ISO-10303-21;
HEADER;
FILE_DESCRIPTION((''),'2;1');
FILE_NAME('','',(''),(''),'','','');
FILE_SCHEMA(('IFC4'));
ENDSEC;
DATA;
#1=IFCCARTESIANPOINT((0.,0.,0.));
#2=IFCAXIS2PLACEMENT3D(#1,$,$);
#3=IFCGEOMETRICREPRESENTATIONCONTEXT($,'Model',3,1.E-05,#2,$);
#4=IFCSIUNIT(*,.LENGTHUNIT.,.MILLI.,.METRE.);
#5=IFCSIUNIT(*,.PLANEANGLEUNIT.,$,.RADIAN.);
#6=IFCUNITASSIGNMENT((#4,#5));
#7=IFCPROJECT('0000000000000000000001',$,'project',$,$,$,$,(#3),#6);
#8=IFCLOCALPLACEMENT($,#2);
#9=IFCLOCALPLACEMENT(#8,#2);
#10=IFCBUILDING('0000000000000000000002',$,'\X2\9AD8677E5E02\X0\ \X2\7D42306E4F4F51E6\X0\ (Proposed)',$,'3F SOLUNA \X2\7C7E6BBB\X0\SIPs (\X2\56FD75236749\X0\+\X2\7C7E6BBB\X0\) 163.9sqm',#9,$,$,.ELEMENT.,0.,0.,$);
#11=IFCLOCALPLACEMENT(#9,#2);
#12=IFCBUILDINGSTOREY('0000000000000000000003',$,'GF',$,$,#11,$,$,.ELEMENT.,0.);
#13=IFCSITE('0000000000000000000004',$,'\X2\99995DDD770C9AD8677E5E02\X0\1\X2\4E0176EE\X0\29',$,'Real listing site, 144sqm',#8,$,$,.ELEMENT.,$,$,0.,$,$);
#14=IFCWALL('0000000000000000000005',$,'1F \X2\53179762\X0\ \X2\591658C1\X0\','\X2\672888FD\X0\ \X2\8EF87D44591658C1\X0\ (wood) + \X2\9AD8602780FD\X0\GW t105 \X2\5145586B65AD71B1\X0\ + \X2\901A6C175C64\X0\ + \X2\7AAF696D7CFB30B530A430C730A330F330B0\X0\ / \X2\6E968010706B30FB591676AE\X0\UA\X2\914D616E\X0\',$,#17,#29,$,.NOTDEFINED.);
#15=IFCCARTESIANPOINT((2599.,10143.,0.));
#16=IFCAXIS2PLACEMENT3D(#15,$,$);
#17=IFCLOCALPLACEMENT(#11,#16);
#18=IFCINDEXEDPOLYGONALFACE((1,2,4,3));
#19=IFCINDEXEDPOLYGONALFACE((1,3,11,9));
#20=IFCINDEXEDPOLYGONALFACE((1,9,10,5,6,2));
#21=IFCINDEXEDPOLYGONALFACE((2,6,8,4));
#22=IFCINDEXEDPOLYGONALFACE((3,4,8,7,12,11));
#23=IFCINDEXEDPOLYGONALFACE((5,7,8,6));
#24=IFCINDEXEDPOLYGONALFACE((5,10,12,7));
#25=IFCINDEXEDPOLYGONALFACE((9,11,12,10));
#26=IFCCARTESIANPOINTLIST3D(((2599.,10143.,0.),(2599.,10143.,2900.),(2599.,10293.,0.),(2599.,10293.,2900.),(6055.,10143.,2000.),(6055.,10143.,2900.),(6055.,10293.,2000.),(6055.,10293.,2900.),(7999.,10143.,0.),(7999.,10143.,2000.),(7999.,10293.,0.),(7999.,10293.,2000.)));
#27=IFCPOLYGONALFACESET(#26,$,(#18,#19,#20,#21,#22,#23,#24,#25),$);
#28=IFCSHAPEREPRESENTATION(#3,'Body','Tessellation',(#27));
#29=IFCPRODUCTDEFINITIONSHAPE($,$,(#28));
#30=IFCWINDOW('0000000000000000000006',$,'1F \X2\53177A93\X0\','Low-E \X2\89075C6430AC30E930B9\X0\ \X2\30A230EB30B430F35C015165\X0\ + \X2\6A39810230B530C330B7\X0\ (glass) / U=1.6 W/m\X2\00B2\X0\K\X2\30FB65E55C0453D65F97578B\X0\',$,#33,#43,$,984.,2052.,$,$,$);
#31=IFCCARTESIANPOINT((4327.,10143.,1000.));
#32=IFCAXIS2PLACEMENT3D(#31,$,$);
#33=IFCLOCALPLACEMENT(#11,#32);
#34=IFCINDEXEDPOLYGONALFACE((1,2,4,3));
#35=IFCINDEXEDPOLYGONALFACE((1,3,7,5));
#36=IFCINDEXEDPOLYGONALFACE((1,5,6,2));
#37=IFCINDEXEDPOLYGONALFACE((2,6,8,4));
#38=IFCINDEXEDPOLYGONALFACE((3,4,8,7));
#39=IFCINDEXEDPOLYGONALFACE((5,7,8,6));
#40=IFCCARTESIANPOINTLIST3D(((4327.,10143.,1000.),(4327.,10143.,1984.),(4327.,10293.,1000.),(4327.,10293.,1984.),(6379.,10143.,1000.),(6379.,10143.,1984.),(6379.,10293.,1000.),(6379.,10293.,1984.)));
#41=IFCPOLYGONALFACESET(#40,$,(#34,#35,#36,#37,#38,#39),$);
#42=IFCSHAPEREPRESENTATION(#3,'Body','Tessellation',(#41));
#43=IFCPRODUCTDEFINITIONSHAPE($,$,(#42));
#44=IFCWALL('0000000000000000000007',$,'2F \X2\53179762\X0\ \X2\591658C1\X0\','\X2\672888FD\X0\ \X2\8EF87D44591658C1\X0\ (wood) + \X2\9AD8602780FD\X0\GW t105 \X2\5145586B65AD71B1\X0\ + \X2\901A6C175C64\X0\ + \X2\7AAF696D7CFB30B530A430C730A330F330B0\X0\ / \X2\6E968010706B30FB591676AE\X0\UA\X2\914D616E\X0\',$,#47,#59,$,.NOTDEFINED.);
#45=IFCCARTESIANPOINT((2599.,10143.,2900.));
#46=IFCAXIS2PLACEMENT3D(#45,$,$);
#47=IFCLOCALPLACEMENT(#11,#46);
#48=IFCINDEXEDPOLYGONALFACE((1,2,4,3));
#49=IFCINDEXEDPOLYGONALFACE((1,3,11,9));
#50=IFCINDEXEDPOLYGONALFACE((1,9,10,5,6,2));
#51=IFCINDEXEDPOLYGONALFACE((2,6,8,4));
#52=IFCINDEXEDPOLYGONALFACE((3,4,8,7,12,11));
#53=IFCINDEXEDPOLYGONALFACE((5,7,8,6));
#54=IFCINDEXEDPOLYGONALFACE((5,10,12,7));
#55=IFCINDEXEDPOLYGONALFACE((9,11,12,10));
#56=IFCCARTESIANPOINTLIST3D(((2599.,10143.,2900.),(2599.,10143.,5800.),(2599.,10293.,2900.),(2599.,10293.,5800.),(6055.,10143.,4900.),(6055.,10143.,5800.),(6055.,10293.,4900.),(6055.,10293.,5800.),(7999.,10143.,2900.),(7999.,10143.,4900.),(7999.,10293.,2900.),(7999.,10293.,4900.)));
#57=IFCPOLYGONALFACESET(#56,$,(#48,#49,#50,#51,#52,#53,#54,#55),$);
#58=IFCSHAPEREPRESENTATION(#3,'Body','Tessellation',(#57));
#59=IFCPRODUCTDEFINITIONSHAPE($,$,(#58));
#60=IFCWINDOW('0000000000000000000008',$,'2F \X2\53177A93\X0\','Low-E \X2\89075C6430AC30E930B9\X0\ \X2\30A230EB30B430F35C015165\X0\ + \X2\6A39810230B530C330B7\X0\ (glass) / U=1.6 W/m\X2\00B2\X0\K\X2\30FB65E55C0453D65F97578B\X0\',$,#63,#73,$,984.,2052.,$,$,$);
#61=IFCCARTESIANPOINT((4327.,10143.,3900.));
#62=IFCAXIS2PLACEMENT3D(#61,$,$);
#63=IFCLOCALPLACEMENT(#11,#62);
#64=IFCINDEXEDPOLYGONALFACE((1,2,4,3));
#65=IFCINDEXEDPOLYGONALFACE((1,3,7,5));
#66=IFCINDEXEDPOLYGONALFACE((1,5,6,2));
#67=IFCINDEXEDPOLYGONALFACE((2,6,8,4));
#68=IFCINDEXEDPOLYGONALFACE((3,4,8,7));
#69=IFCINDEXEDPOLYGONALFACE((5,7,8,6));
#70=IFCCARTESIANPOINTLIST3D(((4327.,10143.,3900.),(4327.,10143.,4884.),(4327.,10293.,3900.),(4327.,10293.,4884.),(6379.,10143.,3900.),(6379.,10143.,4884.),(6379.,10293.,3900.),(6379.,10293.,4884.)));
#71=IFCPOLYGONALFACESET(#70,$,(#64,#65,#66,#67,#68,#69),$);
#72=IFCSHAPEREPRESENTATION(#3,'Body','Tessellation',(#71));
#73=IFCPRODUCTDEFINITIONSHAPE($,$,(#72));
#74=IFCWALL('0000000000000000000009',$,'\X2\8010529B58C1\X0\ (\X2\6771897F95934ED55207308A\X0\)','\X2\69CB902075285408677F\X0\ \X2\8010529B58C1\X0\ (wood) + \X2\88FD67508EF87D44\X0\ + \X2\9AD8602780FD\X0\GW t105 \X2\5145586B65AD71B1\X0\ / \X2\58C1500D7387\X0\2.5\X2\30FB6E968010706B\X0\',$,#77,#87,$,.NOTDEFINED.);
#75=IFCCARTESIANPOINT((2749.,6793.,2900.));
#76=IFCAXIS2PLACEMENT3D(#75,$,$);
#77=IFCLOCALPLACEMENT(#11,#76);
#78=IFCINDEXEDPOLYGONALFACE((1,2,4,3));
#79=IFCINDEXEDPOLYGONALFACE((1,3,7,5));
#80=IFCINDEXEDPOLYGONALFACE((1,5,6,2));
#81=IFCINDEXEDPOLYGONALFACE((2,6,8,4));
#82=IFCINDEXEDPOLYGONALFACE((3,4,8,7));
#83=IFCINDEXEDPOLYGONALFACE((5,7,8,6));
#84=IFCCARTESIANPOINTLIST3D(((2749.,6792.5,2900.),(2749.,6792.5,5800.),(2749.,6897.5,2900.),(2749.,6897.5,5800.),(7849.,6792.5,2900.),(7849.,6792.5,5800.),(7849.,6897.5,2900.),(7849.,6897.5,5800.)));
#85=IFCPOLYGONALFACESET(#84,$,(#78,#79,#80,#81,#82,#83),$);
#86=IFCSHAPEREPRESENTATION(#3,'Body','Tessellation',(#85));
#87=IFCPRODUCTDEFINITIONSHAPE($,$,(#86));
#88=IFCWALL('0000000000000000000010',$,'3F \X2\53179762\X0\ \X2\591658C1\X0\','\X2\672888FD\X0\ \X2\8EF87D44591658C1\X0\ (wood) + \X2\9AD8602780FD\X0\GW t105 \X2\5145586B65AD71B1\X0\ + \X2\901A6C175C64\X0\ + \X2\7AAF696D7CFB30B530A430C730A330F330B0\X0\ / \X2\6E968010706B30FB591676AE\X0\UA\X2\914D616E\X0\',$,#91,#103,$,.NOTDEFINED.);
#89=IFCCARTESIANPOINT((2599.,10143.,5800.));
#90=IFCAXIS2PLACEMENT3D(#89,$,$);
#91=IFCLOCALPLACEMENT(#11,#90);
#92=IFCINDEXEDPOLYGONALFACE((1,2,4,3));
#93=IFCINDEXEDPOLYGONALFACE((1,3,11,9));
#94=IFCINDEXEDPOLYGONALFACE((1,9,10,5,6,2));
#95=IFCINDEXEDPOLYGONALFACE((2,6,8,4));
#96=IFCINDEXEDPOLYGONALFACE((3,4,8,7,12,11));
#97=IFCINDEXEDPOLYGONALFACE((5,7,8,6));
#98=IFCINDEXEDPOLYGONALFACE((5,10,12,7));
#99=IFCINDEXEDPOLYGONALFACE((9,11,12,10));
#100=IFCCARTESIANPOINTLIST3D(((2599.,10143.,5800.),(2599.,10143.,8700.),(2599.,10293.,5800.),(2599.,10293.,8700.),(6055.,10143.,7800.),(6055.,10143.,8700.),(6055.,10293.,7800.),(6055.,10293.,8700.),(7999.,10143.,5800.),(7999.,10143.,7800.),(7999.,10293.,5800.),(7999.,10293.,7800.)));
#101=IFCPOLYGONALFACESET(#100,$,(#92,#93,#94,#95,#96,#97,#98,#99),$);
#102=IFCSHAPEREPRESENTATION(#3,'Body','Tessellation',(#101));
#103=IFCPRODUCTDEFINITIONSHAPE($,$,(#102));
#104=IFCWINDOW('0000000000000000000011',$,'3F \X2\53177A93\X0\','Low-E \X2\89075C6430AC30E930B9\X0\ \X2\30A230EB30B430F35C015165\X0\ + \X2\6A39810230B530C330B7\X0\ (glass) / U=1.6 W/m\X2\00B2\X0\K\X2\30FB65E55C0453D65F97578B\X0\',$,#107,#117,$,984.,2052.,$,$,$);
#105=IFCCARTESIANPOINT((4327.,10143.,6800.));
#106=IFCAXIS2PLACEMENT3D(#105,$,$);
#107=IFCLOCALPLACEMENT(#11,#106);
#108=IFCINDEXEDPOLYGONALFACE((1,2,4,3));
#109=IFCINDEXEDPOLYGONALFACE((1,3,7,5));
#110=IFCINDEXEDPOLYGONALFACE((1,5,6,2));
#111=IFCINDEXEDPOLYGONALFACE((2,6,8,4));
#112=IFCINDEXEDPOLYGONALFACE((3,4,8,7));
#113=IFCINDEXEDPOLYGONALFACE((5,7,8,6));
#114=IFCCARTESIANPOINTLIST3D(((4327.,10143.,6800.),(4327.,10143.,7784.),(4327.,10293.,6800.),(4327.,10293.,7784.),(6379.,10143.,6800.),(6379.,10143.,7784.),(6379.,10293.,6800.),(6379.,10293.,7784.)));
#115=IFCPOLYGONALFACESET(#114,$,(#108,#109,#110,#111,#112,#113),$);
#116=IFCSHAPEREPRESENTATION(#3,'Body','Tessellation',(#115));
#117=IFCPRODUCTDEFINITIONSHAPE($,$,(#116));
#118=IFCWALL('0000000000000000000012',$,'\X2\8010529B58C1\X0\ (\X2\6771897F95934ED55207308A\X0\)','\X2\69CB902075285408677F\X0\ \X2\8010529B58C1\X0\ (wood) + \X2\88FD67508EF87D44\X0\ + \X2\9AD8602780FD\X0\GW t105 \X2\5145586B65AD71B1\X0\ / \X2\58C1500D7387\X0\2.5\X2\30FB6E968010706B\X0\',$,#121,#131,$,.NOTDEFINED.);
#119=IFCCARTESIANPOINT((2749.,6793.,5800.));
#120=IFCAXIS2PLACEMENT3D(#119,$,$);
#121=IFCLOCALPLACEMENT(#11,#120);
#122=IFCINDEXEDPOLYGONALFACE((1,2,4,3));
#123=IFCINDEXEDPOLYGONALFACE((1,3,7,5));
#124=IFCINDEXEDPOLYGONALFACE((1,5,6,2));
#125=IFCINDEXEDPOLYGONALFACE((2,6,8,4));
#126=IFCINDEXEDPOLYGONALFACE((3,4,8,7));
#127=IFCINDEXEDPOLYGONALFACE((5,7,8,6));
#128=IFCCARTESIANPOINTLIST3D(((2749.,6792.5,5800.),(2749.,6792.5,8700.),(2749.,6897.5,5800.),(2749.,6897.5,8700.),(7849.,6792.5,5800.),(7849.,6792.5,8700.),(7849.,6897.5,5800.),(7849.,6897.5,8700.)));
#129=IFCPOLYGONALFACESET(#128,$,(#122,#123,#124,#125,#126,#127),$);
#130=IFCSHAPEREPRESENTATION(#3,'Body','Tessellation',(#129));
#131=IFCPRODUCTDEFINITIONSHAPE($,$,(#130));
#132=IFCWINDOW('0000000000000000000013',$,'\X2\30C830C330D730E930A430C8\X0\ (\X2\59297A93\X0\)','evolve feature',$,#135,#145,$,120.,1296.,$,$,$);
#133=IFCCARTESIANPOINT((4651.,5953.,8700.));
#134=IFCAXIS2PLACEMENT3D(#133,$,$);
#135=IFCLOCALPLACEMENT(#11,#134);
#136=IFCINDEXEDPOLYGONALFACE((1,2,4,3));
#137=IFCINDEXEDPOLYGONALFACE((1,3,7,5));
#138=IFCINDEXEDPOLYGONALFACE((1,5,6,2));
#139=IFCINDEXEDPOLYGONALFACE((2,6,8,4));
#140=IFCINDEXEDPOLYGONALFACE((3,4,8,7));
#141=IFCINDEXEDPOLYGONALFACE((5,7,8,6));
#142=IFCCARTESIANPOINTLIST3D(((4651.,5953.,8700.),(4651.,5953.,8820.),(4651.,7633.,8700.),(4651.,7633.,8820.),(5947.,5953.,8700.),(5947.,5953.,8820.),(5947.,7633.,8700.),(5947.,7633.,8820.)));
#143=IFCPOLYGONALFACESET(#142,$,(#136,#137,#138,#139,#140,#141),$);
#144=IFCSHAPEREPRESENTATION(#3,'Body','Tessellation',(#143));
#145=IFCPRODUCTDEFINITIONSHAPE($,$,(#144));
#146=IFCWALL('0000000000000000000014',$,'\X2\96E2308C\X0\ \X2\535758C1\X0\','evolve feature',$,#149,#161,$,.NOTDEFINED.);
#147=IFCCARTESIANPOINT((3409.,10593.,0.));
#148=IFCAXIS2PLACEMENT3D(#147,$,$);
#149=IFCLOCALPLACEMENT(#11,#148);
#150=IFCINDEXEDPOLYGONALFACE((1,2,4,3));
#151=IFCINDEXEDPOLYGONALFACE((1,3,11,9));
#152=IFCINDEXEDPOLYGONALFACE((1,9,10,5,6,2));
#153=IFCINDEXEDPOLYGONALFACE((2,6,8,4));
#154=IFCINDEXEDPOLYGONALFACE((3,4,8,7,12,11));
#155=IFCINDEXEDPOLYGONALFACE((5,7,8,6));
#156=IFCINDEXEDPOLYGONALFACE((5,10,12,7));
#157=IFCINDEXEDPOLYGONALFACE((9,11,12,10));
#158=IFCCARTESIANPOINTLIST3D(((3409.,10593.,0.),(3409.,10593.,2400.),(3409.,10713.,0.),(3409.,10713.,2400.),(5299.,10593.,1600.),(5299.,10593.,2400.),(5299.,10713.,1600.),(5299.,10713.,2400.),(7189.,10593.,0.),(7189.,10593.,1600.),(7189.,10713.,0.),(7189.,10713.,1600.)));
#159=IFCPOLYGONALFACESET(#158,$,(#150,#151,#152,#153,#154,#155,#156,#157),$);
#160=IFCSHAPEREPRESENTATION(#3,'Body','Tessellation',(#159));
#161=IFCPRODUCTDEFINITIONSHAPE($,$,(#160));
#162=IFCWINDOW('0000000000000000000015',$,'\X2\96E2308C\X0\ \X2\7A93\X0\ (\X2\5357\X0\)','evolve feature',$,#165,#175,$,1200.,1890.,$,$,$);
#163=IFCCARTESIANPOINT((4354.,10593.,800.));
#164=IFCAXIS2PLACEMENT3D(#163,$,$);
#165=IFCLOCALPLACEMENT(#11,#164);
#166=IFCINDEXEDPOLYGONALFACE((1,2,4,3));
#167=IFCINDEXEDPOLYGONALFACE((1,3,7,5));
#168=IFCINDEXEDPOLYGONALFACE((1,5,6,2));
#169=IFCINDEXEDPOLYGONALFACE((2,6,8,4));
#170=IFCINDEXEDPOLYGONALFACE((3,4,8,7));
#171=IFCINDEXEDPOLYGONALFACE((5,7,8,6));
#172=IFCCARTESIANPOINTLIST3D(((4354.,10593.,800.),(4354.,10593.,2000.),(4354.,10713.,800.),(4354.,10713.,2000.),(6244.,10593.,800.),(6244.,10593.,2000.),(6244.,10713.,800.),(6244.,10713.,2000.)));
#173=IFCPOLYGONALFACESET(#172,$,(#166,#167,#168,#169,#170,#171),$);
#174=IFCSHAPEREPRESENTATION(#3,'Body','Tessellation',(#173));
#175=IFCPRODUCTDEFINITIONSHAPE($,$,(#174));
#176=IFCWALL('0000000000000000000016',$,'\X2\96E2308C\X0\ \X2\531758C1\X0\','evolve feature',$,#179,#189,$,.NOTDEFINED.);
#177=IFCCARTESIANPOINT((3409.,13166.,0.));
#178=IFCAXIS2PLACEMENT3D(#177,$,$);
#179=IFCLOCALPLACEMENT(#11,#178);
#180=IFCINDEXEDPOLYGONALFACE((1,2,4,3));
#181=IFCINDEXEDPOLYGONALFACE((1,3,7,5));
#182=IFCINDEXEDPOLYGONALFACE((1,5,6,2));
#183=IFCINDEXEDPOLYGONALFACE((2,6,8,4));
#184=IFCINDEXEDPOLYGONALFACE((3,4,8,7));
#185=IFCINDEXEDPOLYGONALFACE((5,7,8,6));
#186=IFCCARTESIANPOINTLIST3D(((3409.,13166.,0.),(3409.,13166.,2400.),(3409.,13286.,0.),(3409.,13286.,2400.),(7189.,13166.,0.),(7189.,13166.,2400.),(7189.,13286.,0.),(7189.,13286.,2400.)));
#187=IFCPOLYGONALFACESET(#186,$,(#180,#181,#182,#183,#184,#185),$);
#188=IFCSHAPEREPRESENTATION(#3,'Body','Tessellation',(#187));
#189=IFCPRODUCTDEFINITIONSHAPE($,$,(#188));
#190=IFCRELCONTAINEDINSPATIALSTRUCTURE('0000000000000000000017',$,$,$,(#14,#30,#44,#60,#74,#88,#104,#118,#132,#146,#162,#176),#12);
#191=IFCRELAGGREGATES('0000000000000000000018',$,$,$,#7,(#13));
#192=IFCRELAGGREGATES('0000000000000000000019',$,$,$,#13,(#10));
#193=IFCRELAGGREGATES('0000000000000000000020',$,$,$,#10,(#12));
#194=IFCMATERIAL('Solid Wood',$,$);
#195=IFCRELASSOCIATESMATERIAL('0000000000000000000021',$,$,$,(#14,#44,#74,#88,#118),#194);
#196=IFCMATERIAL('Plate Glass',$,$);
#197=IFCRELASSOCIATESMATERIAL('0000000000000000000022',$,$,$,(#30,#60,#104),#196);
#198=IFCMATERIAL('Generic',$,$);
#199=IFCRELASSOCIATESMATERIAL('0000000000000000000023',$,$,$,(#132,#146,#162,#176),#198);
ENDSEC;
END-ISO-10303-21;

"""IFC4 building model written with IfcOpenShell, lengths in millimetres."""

from ifc_helpers import new_model, si_unit, frame, frame_2d, origin, place, context, project, spatial, rectangle, extrude, material, element, fill, save


model = new_model("IFC4")

# Units and contexts
model_context = context("Model", 3, precision=1e-05, world=origin())
ifc_project = project(units=[si_unit("LENGTHUNIT", "METRE", prefix="MILLI"), si_unit("PLANEANGLEUNIT", "RADIAN")], contexts=[model_context])

# Site, building, storey
site_placement = place(None, origin())
site = spatial("IfcSite", under=ifc_project, at=site_placement, Name="香川県高松市1丁目29", ObjectType="Real listing site, 144sqm", CompositionType="ELEMENT", RefElevation=0.0)
building_placement = place(site_placement, origin())
building = spatial("IfcBuilding", under=site, at=building_placement, Name="高松市 終の住処 (Proposed)", ObjectType="3F SOLUNA 籾殻SIPs (国産杉+籾殻) 163.9sqm", CompositionType="ELEMENT", ElevationOfRefHeight=0.0, ElevationOfTerrain=0.0)
storey_placement = place(building_placement, origin())
storey = spatial("IfcBuildingStorey", under=building, at=storey_placement, Name="GF", CompositionType="ELEMENT", Elevation=0.0)

# Shared definitions
ifc_material_1 = material(Name="Generic")

# Wall, opening, window
ifc_material_2 = material(Name="Solid Wood")
wall_1_placement = place(storey_placement, frame((2599.0, 10143.0, 0.0)))
wall_1 = element("IfcWall", 1, at=wall_1_placement, inside=storey, material=ifc_material_2, Name="1F 北面 外壁", Description="木製 軸組外壁 (wood) + 高性能GW t105 充填断熱 + 通気層 + 窯業系サイディング / 準耐火・外皮UA配慮", PredefinedType="NOTDEFINED", context=model_context, shape_type="SweptSolid", body=[
    extrude(rectangle(XDim=5400.0, YDim=150.0, at=frame_2d((2700.0, 75.0))), frame((2599.0, 10143.0, 0.0)), (0.0, 0.0, 1.0), 2900.0),
])
opening_1_placement = place(storey_placement, frame((4327.0, 10143.0, 1000.0)))
opening_1 = element("IfcOpeningElement", 2, at=opening_1_placement, cuts=wall_1, PredefinedType="NOTDEFINED", context=model_context, shape_type="SweptSolid", body=[
    extrude(rectangle(XDim=2052.0, YDim=150.0, at=frame_2d((1026.0, 75.0))), frame((4327.0, 10143.0, 1000.0)), (0.0, 0.0, 1.0), 984.0),
])
ifc_material_3 = material(Name="Plate Glass")
window_1_placement = place(storey_placement, frame((4327.0, 10143.0, 1000.0)))
window_1 = element("IfcWindow", 3, at=window_1_placement, inside=storey, material=ifc_material_3, Name="1F 北窓", Description="Low-E 複層ガラス アルゴン封入 + 樹脂サッシ (glass) / U=1.6 W/m²K・日射取得型", OverallHeight=984.0, OverallWidth=2052.0, context=model_context, shape_type="SweptSolid", body=[
    extrude(rectangle(XDim=2052.0, YDim=150.0, at=frame_2d((1026.0, 75.0))), frame((4327.0, 10143.0, 1000.0)), (0.0, 0.0, 1.0), 984.0),
])
fill(opening_1, window_1)

# Wall, opening, window
wall_2_placement = place(storey_placement, frame((2599.0, 10143.0, 2900.0)))
wall_2 = element("IfcWall", 4, at=wall_2_placement, inside=storey, material=ifc_material_2, Name="2F 北面 外壁", Description="木製 軸組外壁 (wood) + 高性能GW t105 充填断熱 + 通気層 + 窯業系サイディング / 準耐火・外皮UA配慮", PredefinedType="NOTDEFINED", context=model_context, shape_type="SweptSolid", body=[
    extrude(rectangle(XDim=5400.0, YDim=150.0, at=frame_2d((2700.0, 75.0))), frame((2599.0, 10143.0, 2900.0)), (0.0, 0.0, 1.0), 2900.0),
])
opening_2_placement = place(storey_placement, frame((4327.0, 10143.0, 3900.0)))
opening_2 = element("IfcOpeningElement", 5, at=opening_2_placement, cuts=wall_2, PredefinedType="NOTDEFINED", context=model_context, shape_type="SweptSolid", body=[
    extrude(rectangle(XDim=2052.0, YDim=150.0, at=frame_2d((1026.0, 75.0))), frame((4327.0, 10143.0, 3900.0)), (0.0, 0.0, 1.0), 984.0),
])
window_2_placement = place(storey_placement, frame((4327.0, 10143.0, 3900.0)))
window_2 = element("IfcWindow", 6, at=window_2_placement, inside=storey, material=ifc_material_3, Name="2F 北窓", Description="Low-E 複層ガラス アルゴン封入 + 樹脂サッシ (glass) / U=1.6 W/m²K・日射取得型", OverallHeight=984.0, OverallWidth=2052.0, context=model_context, shape_type="SweptSolid", body=[
    extrude(rectangle(XDim=2052.0, YDim=150.0, at=frame_2d((1026.0, 75.0))), frame((4327.0, 10143.0, 3900.0)), (0.0, 0.0, 1.0), 984.0),
])
fill(opening_2, window_2)

# Wall
wall_3_placement = place(storey_placement, frame((2749.0, 6793.0, 2900.0)))
element("IfcWall", 7, at=wall_3_placement, inside=storey, material=ifc_material_2, Name="耐力壁 (東西間仕切り)", Description="構造用合板 耐力壁 (wood) + 製材軸組 + 高性能GW t105 充填断熱 / 壁倍率2.5・準耐火", PredefinedType="NOTDEFINED", context=model_context, shape_type="SweptSolid", body=[
    extrude(rectangle(XDim=5100.0, YDim=105.0, at=frame_2d((2550.0, 52.0))), frame((2749.0, 6793.0, 2900.0)), (0.0, 0.0, 1.0), 2900.0),
])

# Wall, opening, window
wall_4_placement = place(storey_placement, frame((2599.0, 10143.0, 5800.0)))
wall_4 = element("IfcWall", 8, at=wall_4_placement, inside=storey, material=ifc_material_2, Name="3F 北面 外壁", Description="木製 軸組外壁 (wood) + 高性能GW t105 充填断熱 + 通気層 + 窯業系サイディング / 準耐火・外皮UA配慮", PredefinedType="NOTDEFINED", context=model_context, shape_type="SweptSolid", body=[
    extrude(rectangle(XDim=5400.0, YDim=150.0, at=frame_2d((2700.0, 75.0))), frame((2599.0, 10143.0, 5800.0)), (0.0, 0.0, 1.0), 2900.0),
])
opening_3_placement = place(storey_placement, frame((4327.0, 10143.0, 6800.0)))
opening_3 = element("IfcOpeningElement", 9, at=opening_3_placement, cuts=wall_4, PredefinedType="NOTDEFINED", context=model_context, shape_type="SweptSolid", body=[
    extrude(rectangle(XDim=2052.0, YDim=150.0, at=frame_2d((1026.0, 75.0))), frame((4327.0, 10143.0, 6800.0)), (0.0, 0.0, 1.0), 984.0),
])
window_3_placement = place(storey_placement, frame((4327.0, 10143.0, 6800.0)))
window_3 = element("IfcWindow", 10, at=window_3_placement, inside=storey, material=ifc_material_3, Name="3F 北窓", Description="Low-E 複層ガラス アルゴン封入 + 樹脂サッシ (glass) / U=1.6 W/m²K・日射取得型", OverallHeight=984.0, OverallWidth=2052.0, context=model_context, shape_type="SweptSolid", body=[
    extrude(rectangle(XDim=2052.0, YDim=150.0, at=frame_2d((1026.0, 75.0))), frame((4327.0, 10143.0, 6800.0)), (0.0, 0.0, 1.0), 984.0),
])
fill(opening_3, window_3)

# Wall
wall_5_placement = place(storey_placement, frame((2749.0, 6793.0, 5800.0)))
element("IfcWall", 11, at=wall_5_placement, inside=storey, material=ifc_material_2, Name="耐力壁 (東西間仕切り)", Description="構造用合板 耐力壁 (wood) + 製材軸組 + 高性能GW t105 充填断熱 / 壁倍率2.5・準耐火", PredefinedType="NOTDEFINED", context=model_context, shape_type="SweptSolid", body=[
    extrude(rectangle(XDim=5100.0, YDim=105.0, at=frame_2d((2550.0, 52.0))), frame((2749.0, 6793.0, 5800.0)), (0.0, 0.0, 1.0), 2900.0),
])

# Window
window_4_placement = place(storey_placement, frame((4651.0, 5953.0, 8700.0)))
element("IfcWindow", 12, at=window_4_placement, inside=storey, material=ifc_material_1, Name="トップライト (天窓)", Description="evolve feature", OverallHeight=120.0, OverallWidth=1296.0, context=model_context, shape_type="SweptSolid", body=[
    extrude(rectangle(XDim=1296.0, YDim=1680.0, at=frame_2d((648.0, 840.0))), frame((4651.0, 5953.0, 8700.0)), (0.0, 0.0, 1.0), 120.0),
])

# Wall, opening, window
wall_6_placement = place(storey_placement, frame((3409.0, 10593.0, 0.0)))
wall_6 = element("IfcWall", 13, at=wall_6_placement, inside=storey, material=ifc_material_1, Name="離れ 南壁", Description="evolve feature", PredefinedType="NOTDEFINED", context=model_context, shape_type="SweptSolid", body=[
    extrude(rectangle(XDim=3780.0, YDim=120.0, at=frame_2d((1890.0, 60.0))), frame((3409.0, 10593.0, 0.0)), (0.0, 0.0, 1.0), 2400.0),
])
opening_4_placement = place(storey_placement, frame((4354.0, 10593.0, 800.0)))
opening_4 = element("IfcOpeningElement", 14, at=opening_4_placement, cuts=wall_6, PredefinedType="NOTDEFINED", context=model_context, shape_type="SweptSolid", body=[
    extrude(rectangle(XDim=1890.0, YDim=120.0, at=frame_2d((945.0, 60.0))), frame((4354.0, 10593.0, 800.0)), (0.0, 0.0, 1.0), 1200.0),
])
window_5_placement = place(storey_placement, frame((4354.0, 10593.0, 800.0)))
window_5 = element("IfcWindow", 15, at=window_5_placement, inside=storey, material=ifc_material_1, Name="離れ 窓 (南)", Description="evolve feature", OverallHeight=1200.0, OverallWidth=1890.0, context=model_context, shape_type="SweptSolid", body=[
    extrude(rectangle(XDim=1890.0, YDim=120.0, at=frame_2d((945.0, 60.0))), frame((4354.0, 10593.0, 800.0)), (0.0, 0.0, 1.0), 1200.0),
])
fill(opening_4, window_5)

# Wall
wall_7_placement = place(storey_placement, frame((3409.0, 13166.0, 0.0)))
element("IfcWall", 16, at=wall_7_placement, inside=storey, material=ifc_material_1, Name="離れ 北壁", Description="evolve feature", PredefinedType="NOTDEFINED", context=model_context, shape_type="SweptSolid", body=[
    extrude(rectangle(XDim=3780.0, YDim=120.0, at=frame_2d((1890.0, 60.0))), frame((3409.0, 13166.0, 0.0)), (0.0, 0.0, 1.0), 2400.0),
])

save(model, "model.ifc")
